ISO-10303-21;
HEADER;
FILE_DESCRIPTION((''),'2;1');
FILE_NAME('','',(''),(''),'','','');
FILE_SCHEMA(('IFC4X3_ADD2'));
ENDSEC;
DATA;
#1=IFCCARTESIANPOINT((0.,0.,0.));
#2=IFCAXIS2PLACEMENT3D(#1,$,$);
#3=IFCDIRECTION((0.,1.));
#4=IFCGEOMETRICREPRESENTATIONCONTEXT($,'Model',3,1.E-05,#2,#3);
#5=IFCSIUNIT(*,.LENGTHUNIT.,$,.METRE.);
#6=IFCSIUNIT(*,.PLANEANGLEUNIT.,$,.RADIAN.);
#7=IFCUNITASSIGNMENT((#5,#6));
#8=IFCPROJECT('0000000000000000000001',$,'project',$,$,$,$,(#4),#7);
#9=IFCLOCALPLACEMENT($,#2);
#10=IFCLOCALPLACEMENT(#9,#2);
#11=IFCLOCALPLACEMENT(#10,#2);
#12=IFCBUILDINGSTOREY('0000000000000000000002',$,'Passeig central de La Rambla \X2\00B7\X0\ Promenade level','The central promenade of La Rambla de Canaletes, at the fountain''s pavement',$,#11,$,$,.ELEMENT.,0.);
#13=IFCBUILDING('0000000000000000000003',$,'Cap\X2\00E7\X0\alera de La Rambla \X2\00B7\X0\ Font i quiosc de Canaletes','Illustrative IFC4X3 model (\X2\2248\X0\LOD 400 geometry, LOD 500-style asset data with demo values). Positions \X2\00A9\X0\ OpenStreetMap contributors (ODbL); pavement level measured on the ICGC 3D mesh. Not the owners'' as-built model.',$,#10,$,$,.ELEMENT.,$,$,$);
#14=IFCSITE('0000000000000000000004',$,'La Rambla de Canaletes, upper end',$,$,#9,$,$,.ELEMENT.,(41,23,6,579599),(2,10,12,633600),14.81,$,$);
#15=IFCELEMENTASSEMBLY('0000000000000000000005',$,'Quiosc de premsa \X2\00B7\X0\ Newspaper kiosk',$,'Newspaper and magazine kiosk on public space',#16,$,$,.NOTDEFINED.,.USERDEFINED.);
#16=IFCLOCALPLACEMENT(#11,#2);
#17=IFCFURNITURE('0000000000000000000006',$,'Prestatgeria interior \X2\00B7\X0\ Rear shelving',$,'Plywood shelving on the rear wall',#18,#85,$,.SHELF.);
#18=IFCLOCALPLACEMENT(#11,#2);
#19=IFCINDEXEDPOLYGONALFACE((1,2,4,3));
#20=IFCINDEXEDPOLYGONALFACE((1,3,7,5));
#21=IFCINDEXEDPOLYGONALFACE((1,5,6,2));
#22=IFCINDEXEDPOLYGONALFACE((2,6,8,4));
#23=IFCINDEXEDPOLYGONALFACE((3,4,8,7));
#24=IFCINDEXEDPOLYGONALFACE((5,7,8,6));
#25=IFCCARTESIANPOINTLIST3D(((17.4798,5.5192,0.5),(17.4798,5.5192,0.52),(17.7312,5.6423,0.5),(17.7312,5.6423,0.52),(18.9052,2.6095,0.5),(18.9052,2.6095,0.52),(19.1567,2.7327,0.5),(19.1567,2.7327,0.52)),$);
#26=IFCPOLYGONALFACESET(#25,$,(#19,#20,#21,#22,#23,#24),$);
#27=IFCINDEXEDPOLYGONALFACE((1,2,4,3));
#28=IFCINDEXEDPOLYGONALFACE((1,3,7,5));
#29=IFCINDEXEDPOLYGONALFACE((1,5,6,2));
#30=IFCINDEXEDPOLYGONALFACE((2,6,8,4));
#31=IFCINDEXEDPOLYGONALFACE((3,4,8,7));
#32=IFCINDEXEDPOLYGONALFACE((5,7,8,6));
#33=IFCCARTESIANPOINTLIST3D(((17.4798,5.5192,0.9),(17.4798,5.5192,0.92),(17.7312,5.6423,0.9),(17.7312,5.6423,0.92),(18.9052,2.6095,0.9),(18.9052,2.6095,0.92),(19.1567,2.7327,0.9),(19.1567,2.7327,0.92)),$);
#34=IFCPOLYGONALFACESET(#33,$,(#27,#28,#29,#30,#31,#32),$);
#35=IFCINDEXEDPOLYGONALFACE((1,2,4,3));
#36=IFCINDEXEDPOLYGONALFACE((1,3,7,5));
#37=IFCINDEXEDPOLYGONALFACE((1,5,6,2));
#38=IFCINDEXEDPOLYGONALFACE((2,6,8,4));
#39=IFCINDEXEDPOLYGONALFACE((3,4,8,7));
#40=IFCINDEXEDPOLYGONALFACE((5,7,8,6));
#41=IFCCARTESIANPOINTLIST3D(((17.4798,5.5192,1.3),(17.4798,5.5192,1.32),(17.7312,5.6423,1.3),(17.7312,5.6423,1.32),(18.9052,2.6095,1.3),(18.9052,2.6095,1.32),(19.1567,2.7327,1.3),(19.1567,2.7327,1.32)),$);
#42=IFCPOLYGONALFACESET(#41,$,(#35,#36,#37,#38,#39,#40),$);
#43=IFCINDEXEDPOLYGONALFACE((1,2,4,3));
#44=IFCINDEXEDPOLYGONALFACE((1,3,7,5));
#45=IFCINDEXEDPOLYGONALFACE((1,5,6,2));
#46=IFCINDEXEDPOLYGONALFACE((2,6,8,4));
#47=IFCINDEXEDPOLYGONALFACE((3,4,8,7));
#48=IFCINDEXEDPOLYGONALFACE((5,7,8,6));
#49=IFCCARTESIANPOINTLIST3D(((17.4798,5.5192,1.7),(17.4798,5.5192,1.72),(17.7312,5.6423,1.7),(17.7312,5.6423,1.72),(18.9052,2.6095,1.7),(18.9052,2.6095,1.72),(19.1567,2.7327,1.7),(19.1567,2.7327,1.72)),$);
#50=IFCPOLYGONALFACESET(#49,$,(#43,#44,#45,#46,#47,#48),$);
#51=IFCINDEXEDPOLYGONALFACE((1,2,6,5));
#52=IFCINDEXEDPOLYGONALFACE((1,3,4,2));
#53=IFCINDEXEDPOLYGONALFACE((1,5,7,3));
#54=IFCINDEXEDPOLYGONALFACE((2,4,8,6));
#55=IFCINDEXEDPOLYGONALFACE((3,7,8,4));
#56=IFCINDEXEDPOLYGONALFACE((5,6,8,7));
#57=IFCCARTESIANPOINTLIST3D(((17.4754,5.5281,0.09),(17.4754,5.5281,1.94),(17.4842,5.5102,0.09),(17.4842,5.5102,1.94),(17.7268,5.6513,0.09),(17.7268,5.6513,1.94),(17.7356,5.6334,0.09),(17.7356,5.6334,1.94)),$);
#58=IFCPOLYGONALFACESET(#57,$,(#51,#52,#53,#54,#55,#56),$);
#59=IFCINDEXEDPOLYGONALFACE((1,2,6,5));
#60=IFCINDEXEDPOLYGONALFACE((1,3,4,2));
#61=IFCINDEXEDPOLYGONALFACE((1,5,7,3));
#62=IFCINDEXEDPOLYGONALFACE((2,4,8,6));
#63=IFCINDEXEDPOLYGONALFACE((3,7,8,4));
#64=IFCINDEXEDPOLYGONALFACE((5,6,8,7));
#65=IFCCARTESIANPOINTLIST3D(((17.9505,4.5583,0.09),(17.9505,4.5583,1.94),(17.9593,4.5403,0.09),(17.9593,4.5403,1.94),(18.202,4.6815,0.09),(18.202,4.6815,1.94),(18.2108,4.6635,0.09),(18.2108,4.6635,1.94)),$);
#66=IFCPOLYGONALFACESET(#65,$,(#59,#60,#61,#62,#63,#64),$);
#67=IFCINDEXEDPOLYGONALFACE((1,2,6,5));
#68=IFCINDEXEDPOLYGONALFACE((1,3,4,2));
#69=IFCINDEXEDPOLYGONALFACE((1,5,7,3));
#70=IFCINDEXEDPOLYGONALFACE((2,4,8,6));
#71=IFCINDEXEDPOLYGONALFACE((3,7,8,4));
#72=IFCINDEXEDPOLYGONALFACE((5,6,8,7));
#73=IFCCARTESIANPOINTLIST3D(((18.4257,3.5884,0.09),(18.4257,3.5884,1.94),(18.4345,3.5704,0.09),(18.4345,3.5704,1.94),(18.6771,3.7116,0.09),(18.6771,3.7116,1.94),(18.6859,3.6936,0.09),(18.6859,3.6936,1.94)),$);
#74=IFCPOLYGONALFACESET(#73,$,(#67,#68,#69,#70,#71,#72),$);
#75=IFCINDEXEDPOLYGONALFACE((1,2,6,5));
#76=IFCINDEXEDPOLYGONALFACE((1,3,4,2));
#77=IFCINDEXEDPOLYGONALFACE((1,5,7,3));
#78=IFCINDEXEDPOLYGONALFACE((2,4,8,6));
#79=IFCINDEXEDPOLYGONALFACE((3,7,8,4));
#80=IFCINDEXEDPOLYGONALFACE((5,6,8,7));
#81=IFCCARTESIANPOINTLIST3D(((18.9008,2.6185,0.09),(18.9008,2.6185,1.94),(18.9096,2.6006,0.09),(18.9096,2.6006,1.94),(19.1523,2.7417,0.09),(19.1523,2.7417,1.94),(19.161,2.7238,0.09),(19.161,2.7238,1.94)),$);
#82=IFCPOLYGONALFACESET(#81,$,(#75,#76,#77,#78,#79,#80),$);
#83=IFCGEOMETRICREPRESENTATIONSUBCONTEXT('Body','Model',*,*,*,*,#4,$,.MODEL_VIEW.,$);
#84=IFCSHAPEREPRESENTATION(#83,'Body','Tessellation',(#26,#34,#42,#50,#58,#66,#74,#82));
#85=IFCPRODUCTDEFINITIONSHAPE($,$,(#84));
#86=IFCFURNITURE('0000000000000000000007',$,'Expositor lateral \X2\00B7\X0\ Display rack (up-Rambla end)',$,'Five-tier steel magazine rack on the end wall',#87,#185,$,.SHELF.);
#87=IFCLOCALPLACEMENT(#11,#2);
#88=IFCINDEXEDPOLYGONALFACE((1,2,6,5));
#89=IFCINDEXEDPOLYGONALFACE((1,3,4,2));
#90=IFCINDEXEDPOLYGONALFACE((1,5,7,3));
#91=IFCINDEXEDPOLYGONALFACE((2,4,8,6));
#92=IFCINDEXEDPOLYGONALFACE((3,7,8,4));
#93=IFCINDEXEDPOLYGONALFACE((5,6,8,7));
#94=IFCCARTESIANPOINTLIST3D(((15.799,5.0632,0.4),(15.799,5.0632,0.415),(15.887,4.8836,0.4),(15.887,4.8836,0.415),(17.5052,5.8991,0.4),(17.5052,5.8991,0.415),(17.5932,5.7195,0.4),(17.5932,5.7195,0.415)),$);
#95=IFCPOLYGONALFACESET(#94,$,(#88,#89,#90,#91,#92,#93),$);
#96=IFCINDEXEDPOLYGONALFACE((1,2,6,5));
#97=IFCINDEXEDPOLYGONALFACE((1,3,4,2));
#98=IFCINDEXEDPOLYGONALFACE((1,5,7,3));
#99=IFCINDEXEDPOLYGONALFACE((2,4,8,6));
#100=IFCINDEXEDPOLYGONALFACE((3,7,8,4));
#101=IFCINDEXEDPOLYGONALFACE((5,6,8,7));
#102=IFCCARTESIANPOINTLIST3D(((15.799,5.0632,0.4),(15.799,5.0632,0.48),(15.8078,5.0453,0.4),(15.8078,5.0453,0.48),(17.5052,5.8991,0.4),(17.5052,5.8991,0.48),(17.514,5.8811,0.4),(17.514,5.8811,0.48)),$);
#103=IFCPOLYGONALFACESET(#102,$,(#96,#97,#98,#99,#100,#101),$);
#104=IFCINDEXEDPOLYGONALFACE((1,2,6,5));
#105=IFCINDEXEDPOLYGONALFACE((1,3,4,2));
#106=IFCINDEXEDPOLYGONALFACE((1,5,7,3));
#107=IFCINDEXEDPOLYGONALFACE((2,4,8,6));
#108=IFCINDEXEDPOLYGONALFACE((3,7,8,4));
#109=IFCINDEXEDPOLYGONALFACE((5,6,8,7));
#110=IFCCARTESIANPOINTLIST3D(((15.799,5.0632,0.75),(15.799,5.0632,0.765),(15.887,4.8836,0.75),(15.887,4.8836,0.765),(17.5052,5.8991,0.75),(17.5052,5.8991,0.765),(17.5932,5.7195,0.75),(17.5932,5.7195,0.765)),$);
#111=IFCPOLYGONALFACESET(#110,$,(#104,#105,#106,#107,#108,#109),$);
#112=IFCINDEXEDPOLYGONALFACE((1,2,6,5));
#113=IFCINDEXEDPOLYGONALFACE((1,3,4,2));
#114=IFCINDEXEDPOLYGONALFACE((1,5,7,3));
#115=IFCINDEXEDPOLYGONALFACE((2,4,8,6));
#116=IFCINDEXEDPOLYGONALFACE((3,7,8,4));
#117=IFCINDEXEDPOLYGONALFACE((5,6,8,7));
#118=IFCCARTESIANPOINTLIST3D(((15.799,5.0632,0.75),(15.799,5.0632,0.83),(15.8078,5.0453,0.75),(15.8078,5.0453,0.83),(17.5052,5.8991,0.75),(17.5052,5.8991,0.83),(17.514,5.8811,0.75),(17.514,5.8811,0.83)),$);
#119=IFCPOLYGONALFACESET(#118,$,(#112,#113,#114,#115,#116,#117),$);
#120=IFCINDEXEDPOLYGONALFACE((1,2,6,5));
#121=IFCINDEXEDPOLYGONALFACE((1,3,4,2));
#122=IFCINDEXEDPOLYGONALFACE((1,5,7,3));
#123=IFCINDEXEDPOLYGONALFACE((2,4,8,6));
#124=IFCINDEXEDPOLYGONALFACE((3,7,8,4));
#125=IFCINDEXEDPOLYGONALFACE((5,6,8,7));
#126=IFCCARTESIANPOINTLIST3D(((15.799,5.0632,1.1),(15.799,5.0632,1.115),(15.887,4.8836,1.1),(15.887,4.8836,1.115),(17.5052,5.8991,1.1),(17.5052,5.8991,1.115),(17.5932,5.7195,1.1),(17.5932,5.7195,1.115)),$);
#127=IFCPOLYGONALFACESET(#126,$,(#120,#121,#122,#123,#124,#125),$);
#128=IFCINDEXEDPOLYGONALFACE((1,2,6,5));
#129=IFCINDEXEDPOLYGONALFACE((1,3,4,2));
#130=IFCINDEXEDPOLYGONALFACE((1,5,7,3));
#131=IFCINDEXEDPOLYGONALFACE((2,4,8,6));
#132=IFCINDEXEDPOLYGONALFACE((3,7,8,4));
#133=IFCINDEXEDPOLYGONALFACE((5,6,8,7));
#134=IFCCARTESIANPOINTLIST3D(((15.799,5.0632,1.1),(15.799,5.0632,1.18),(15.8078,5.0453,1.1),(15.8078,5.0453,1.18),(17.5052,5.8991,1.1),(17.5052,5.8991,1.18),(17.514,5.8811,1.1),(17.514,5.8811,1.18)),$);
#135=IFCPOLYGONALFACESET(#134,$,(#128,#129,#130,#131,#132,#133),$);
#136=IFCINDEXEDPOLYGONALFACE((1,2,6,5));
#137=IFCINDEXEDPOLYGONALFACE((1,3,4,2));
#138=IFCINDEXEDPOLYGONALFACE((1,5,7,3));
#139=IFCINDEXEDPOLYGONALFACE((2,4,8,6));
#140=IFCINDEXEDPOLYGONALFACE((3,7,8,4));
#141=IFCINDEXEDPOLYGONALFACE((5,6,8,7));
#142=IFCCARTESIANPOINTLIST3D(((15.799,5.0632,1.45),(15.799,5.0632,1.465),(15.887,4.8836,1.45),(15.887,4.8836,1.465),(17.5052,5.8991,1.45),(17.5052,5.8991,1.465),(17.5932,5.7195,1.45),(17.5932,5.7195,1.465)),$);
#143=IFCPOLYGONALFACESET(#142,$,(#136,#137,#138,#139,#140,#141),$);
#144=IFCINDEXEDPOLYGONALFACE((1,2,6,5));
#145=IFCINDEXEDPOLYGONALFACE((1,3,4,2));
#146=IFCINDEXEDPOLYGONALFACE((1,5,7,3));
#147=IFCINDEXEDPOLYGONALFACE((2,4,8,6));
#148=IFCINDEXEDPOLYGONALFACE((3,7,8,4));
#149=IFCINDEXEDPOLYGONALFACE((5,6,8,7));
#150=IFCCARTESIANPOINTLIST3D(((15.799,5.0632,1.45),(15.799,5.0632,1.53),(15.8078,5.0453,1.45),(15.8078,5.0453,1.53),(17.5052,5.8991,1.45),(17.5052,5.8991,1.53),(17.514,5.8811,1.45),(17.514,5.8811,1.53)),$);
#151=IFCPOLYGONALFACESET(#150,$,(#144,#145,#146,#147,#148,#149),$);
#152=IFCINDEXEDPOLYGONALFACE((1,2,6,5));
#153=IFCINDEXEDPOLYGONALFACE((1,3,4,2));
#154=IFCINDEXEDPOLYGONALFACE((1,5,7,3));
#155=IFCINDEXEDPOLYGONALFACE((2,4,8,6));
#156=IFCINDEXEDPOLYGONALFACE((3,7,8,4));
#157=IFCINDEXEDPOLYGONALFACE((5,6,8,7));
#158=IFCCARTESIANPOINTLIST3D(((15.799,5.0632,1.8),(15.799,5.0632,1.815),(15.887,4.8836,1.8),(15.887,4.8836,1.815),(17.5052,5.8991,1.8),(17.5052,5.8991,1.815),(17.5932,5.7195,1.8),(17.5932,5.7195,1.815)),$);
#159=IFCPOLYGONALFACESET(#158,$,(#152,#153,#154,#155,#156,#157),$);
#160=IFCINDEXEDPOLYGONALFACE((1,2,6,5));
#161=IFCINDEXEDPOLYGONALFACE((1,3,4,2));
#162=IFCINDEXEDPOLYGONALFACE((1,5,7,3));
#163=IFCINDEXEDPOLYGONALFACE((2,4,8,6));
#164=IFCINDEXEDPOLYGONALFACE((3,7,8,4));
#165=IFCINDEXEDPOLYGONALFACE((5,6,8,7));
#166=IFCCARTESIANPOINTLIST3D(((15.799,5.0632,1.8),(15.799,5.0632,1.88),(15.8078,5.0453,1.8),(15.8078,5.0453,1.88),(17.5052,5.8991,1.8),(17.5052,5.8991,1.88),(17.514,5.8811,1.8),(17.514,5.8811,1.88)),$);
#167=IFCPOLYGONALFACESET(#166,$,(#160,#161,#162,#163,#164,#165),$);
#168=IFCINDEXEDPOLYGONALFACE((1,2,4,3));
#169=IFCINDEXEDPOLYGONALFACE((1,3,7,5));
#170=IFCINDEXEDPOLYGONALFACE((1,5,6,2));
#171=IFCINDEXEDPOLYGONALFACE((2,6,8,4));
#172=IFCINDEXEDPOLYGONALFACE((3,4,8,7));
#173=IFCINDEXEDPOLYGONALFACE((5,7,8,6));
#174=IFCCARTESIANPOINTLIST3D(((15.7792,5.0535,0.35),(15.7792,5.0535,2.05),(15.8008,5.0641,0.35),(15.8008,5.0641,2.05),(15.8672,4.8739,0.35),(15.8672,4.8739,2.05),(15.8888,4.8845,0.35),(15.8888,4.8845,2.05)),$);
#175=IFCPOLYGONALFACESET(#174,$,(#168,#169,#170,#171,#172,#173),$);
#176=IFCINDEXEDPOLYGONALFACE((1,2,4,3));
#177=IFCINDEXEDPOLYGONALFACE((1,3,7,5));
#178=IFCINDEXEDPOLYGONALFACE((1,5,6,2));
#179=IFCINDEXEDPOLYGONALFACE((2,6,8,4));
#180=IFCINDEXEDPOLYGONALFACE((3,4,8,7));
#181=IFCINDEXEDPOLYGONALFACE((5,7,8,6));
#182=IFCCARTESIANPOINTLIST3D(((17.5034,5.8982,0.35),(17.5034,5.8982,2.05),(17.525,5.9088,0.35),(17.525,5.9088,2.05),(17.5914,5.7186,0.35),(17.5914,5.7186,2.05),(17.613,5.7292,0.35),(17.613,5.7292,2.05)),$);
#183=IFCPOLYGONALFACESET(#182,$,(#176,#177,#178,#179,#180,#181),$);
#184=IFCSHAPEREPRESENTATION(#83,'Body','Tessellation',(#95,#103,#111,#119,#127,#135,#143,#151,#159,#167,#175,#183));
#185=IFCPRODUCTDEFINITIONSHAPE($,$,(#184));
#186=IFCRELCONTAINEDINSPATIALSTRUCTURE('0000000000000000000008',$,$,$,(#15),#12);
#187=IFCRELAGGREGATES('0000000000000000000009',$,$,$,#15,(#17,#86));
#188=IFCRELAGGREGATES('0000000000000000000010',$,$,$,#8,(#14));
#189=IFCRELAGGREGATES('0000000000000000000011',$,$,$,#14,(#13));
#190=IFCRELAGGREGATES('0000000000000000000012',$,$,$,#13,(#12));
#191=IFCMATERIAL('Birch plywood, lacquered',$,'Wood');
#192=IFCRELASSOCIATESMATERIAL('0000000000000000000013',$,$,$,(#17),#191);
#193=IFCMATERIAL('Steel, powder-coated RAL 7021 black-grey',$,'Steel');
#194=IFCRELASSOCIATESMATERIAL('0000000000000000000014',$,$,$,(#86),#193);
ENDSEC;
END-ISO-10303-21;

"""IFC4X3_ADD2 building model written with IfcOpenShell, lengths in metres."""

from ifc_helpers import new_model, si_unit, direction, frame, frame_2d, origin, place, context, subcontext, project, spatial, rectangle, extrude, material, element, aggregate, save


model = new_model("IFC4X3_ADD2")

# Units and contexts
model_context = context("Model", 3, precision=1e-05, world=origin(), true_north=direction((0.0, 1.0)))
body_context = subcontext(model_context, "Body", "Model", "MODEL_VIEW")
ifc_project = project(units=[si_unit("LENGTHUNIT", "METRE"), si_unit("PLANEANGLEUNIT", "RADIAN")], contexts=[model_context])

# Site, building, storey
site_placement = place(None, origin())
site = spatial("IfcSite", under=ifc_project, at=site_placement, Name="La Rambla de Canaletes, upper end", CompositionType="ELEMENT", RefLatitude=(41, 23, 6, 579599), RefLongitude=(2, 10, 12, 633600), RefElevation=14.81)
building_placement = place(site_placement, origin())
building = spatial("IfcBuilding", under=site, at=building_placement, Name="Capçalera de La Rambla · Font i quiosc de Canaletes", Description="Illustrative IFC4X3 model (≈LOD 400 geometry, LOD 500-style asset data with demo values). Positions © OpenStreetMap contributors (ODbL); pavement level measured on the ICGC 3D mesh. Not the owners' as-built model.", CompositionType="ELEMENT")
storey_placement = place(building_placement, origin())
storey = spatial("IfcBuildingStorey", under=building, at=storey_placement, Name="Passeig central de La Rambla · Promenade level", Description="The central promenade of La Rambla de Canaletes, at the fountain's pavement", CompositionType="ELEMENT", Elevation=0.0)

# Element assembly
assembly_1_placement = place(building_placement, origin())
assembly_1 = element("IfcElementAssembly", 1, at=assembly_1_placement, inside=storey, Name="Quiosc de premsa · Newspaper kiosk", ObjectType="Newspaper and magazine kiosk on public space", AssemblyPlace="NOTDEFINED", PredefinedType="USERDEFINED")
ifc_material_1 = material(Name="Steel, powder-coated RAL 7021 black-grey", Category="Steel")

# Furniture
ifc_material_2 = material(Name="Birch plywood, lacquered", Category="Wood")
furniture_1_placement = place(building_placement, origin())
furniture_1 = element("IfcFurniture", 2, at=furniture_1_placement, material=ifc_material_2, Name="Prestatgeria interior · Rear shelving", ObjectType="Plywood shelving on the rear wall", PredefinedType="SHELF", context=body_context, shape_type="SweptSolid", body=[
    extrude(rectangle(XDim=3.24, YDim=0.28, at=frame_2d((0.0, 0.0), x_axis=(0.439939, -0.898028))), frame((18.3182, 4.1259, 0.5)), (0.0, 0.0, 1.0), 0.02),
    extrude(rectangle(XDim=3.24, YDim=0.28, at=frame_2d((0.0, 0.0), x_axis=(0.439939, -0.898028))), frame((18.3182, 4.1259, 0.9)), (0.0, 0.0, 1.0), 0.02),
    extrude(rectangle(XDim=3.24, YDim=0.28, at=frame_2d((0.0, 0.0), x_axis=(0.439939, -0.898028))), frame((18.3182, 4.1259, 1.3)), (0.0, 0.0, 1.0), 0.02),
    extrude(rectangle(XDim=3.24, YDim=0.28, at=frame_2d((0.0, 0.0), x_axis=(0.439939, -0.898028))), frame((18.3182, 4.1259, 1.7)), (0.0, 0.0, 1.0), 0.02),
    extrude(rectangle(XDim=0.02, YDim=0.28, at=frame_2d((0.0, 0.0), x_axis=(0.439939, -0.898028))), frame((17.6055, 5.5807, 0.09)), (0.0, 0.0, 1.0), 1.85),
    extrude(rectangle(XDim=0.02, YDim=0.28, at=frame_2d((0.0, 0.0), x_axis=(0.439939, -0.898028))), frame((18.0807, 4.6109, 0.09)), (0.0, 0.0, 1.0), 1.85),
    extrude(rectangle(XDim=0.02, YDim=0.28, at=frame_2d((0.0, 0.0), x_axis=(0.439939, -0.898028))), frame((18.5558, 3.641, 0.09)), (0.0, 0.0, 1.0), 1.85),
    extrude(rectangle(XDim=0.02, YDim=0.28, at=frame_2d((0.0, 0.0), x_axis=(0.439939, -0.898028))), frame((19.0309, 2.6711, 0.09)), (0.0, 0.0, 1.0), 1.85),
])
furniture_2_placement = place(building_placement, origin())
furniture_2 = element("IfcFurniture", 3, at=furniture_2_placement, material=ifc_material_1, Name="Expositor lateral · Display rack (up-Rambla end)", ObjectType="Five-tier steel magazine rack on the end wall", PredefinedType="SHELF", context=body_context, shape_type="SweptSolid", body=[
    extrude(rectangle(XDim=0.2, YDim=1.9, at=frame_2d((0.0, 0.0), x_axis=(0.439939, -0.898028))), frame((16.6961, 5.3914, 0.4)), (0.0, 0.0, 1.0), 0.015),
    extrude(rectangle(XDim=0.02, YDim=1.9, at=frame_2d((0.0, 0.0), x_axis=(0.439939, -0.898028))), frame((16.6565, 5.4722, 0.4)), (0.0, 0.0, 1.0), 0.08),
    extrude(rectangle(XDim=0.2, YDim=1.9, at=frame_2d((0.0, 0.0), x_axis=(0.439939, -0.898028))), frame((16.6961, 5.3914, 0.75)), (0.0, 0.0, 1.0), 0.015),
    extrude(rectangle(XDim=0.02, YDim=1.9, at=frame_2d((0.0, 0.0), x_axis=(0.439939, -0.898028))), frame((16.6565, 5.4722, 0.75)), (0.0, 0.0, 1.0), 0.08),
    extrude(rectangle(XDim=0.2, YDim=1.9, at=frame_2d((0.0, 0.0), x_axis=(0.439939, -0.898028))), frame((16.6961, 5.3914, 1.1)), (0.0, 0.0, 1.0), 0.015),
    extrude(rectangle(XDim=0.02, YDim=1.9, at=frame_2d((0.0, 0.0), x_axis=(0.439939, -0.898028))), frame((16.6565, 5.4722, 1.1)), (0.0, 0.0, 1.0), 0.08),
    extrude(rectangle(XDim=0.2, YDim=1.9, at=frame_2d((0.0, 0.0), x_axis=(0.439939, -0.898028))), frame((16.6961, 5.3914, 1.45)), (0.0, 0.0, 1.0), 0.015),
    extrude(rectangle(XDim=0.02, YDim=1.9, at=frame_2d((0.0, 0.0), x_axis=(0.439939, -0.898028))), frame((16.6565, 5.4722, 1.45)), (0.0, 0.0, 1.0), 0.08),
    extrude(rectangle(XDim=0.2, YDim=1.9, at=frame_2d((0.0, 0.0), x_axis=(0.439939, -0.898028))), frame((16.6961, 5.3914, 1.8)), (0.0, 0.0, 1.0), 0.015),
    extrude(rectangle(XDim=0.02, YDim=1.9, at=frame_2d((0.0, 0.0), x_axis=(0.439939, -0.898028))), frame((16.6565, 5.4722, 1.8)), (0.0, 0.0, 1.0), 0.08),
    extrude(rectangle(XDim=0.2, YDim=0.024, at=frame_2d((0.0, 0.0), x_axis=(0.439939, -0.898028))), frame((15.834, 4.969, 0.35)), (0.0, 0.0, 1.0), 1.7),
    extrude(rectangle(XDim=0.2, YDim=0.024, at=frame_2d((0.0, 0.0), x_axis=(0.439939, -0.898028))), frame((17.5582, 5.8137, 0.35)), (0.0, 0.0, 1.0), 1.7),
])

aggregate(assembly_1, [furniture_1, furniture_2])

save(model, "model.ifc")
